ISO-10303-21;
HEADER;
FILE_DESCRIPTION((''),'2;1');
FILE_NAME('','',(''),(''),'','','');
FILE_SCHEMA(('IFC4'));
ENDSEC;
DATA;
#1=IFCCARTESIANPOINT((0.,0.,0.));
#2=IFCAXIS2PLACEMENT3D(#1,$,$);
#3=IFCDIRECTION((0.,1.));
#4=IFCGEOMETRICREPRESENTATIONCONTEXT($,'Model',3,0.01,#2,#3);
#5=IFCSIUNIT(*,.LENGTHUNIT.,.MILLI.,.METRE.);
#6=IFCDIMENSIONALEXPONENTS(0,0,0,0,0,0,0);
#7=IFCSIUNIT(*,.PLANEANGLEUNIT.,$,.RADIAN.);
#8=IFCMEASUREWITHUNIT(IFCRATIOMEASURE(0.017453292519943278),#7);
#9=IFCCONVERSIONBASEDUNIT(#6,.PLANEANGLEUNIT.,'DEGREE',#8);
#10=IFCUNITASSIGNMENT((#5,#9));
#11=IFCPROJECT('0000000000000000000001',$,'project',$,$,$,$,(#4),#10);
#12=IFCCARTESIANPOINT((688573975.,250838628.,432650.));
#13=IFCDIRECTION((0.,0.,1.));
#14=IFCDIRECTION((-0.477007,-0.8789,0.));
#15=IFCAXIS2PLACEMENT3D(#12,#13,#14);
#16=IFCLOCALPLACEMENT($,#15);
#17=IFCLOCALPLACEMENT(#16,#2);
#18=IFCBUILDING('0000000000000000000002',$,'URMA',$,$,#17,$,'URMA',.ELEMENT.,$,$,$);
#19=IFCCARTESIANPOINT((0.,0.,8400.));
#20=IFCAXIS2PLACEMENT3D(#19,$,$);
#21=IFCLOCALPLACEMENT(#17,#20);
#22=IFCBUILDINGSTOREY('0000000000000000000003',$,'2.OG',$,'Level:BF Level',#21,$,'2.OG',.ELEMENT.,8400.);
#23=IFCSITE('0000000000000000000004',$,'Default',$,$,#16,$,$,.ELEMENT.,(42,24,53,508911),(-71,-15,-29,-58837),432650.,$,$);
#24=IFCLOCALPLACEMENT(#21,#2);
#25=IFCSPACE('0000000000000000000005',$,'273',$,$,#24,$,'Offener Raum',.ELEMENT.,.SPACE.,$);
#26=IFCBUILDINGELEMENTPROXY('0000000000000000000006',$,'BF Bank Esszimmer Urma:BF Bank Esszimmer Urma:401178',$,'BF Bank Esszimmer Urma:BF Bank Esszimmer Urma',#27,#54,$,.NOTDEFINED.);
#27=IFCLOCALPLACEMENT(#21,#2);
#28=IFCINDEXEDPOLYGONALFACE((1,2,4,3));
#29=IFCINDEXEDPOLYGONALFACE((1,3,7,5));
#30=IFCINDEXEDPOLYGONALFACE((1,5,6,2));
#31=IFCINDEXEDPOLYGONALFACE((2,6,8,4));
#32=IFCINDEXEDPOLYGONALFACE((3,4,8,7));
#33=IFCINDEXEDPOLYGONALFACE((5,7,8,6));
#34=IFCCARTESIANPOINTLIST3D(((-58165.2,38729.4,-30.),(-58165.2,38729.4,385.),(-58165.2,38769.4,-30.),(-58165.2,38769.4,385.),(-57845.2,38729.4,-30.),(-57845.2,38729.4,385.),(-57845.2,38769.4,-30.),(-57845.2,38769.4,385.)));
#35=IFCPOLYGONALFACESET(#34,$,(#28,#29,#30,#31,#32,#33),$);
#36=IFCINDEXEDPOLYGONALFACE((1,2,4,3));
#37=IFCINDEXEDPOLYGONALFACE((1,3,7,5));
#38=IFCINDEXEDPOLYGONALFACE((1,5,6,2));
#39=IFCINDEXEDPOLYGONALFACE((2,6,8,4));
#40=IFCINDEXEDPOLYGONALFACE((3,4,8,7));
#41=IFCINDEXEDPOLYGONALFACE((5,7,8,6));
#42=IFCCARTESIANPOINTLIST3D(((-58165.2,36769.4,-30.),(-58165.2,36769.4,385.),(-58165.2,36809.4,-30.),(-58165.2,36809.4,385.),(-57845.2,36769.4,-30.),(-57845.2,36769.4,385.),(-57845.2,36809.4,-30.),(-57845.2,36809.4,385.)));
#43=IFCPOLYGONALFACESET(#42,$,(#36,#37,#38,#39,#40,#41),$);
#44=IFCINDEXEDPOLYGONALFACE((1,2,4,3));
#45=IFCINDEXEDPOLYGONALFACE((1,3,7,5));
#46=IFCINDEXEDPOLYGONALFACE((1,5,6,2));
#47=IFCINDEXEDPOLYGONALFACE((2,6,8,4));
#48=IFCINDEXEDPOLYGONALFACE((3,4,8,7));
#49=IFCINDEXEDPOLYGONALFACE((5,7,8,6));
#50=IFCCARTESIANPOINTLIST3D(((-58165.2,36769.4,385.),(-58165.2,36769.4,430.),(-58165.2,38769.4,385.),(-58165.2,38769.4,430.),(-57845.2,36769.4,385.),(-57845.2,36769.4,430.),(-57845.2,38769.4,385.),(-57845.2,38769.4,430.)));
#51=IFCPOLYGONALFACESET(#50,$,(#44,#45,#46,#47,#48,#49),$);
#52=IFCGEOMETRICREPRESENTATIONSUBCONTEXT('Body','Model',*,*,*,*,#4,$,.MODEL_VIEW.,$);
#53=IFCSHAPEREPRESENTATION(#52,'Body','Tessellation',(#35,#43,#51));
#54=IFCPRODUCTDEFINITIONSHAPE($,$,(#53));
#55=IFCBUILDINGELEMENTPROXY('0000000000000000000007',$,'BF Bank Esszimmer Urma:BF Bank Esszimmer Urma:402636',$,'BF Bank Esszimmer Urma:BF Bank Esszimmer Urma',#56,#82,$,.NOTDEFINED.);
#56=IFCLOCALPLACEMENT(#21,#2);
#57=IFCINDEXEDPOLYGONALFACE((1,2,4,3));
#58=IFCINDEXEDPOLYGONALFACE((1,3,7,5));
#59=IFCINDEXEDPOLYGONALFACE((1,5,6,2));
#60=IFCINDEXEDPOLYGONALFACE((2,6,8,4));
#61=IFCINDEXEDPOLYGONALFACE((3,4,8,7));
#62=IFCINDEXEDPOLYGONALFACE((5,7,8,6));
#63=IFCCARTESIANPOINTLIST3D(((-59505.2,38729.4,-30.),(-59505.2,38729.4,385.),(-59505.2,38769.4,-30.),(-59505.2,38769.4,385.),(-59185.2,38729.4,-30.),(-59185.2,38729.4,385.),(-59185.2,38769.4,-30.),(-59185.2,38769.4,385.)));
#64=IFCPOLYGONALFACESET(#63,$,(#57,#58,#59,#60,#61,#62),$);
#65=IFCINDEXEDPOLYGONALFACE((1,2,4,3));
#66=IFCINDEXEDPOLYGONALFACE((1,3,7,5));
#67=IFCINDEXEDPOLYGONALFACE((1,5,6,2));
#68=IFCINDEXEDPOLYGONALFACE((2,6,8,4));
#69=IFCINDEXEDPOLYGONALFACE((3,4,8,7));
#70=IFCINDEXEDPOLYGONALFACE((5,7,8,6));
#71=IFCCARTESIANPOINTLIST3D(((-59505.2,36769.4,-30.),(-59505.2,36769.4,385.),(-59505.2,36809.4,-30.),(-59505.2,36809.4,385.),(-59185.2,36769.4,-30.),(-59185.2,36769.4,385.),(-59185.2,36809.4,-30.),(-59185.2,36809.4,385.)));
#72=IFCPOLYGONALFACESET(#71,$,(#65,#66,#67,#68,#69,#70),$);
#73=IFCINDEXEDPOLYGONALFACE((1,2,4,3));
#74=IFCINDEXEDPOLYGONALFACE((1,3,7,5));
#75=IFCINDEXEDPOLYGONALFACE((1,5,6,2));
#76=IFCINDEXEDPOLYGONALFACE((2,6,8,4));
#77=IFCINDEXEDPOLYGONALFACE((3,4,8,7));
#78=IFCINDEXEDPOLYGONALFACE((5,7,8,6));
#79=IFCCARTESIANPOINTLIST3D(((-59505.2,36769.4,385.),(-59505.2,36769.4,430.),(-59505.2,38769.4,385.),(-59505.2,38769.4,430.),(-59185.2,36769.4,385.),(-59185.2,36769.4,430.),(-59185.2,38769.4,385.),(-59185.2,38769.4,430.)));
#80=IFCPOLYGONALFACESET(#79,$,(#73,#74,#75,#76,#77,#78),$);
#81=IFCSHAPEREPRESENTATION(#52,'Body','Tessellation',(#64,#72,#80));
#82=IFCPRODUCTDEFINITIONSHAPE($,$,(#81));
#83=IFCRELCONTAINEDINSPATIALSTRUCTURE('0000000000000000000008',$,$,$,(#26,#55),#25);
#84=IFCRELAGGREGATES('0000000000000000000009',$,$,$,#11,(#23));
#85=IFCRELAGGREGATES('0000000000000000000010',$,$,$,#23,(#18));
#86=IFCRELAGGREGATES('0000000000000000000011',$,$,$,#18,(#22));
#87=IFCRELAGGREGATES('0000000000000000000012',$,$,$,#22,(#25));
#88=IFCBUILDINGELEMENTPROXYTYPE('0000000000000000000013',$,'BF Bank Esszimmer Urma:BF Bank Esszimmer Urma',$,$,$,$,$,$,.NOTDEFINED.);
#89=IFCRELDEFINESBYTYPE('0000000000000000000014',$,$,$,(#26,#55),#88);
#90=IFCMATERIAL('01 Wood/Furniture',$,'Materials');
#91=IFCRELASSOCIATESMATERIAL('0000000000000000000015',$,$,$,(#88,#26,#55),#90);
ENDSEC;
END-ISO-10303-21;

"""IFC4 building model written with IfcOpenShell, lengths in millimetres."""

from ifc_helpers import new_model, entity, si_unit, converted_unit, direction, frame, origin, place, context, subcontext, project, spatial, indexed_curve, outline, extrude, source, transform, mapped, material, type_object, type_shapes, element, save


model = new_model("IFC4")

# Units and contexts
model_context = context("Model", 3, precision=0.01, world=origin(), true_north=direction((0.0, 1.0)))
body_context = subcontext(model_context, "Body", "Model", "MODEL_VIEW")
ifc_project = project(units=[si_unit("LENGTHUNIT", "METRE", prefix="MILLI"), converted_unit("PLANEANGLEUNIT", "DEGREE", entity("IfcRatioMeasure", 0.017453292519943278), si_unit("PLANEANGLEUNIT", "RADIAN"), dimensions=[0, 0, 0, 0, 0, 0, 0])], contexts=[model_context])

# Site, building, storey
site_placement = place(None, frame((688573975.0, 250838628.0, 432650.0), z_axis=(0.0, 0.0, 1.0), x_axis=(-0.477007, -0.8789, 0.0)))
site = spatial("IfcSite", under=ifc_project, at=site_placement, Name="Default", CompositionType="ELEMENT", RefLatitude=(42, 24, 53, 508911), RefLongitude=(-71, -15, -29, -58837), RefElevation=432650.0)
building_placement = place(site_placement, origin())
building = spatial("IfcBuilding", under=site, at=building_placement, Name="URMA", LongName="URMA", CompositionType="ELEMENT")
storey_placement = place(building_placement, frame((0.0, 0.0, 8400.0)))
storey = spatial("IfcBuildingStorey", under=building, at=storey_placement, Name="2.OG", ObjectType="Level:BF Level", LongName="2.OG", CompositionType="ELEMENT", Elevation=8400.0)

# Shared definitions
space_1_placement = place(storey_placement, origin())
space_1 = spatial("IfcSpace", under=storey, at=space_1_placement, Name="273", LongName="Offener Raum", CompositionType="ELEMENT", PredefinedType="SPACE")

# Building element proxies
ifc_material_1 = material(Name="01 Wood/Furniture", Category="Materials")
building_element_proxy_type_1 = type_object("IfcBuildingElementProxyType", Name="BF Bank Esszimmer Urma:BF Bank Esszimmer Urma", PredefinedType="NOTDEFINED", material=ifc_material_1)
shared_shape_1 = source(origin(), body_context, "Body", "SweptSolid", [
    extrude(outline(indexed_curve([(-160.0, -20.0), (160.0, -20.0), (160.0, 20.0), (-160.0, 20.0), (-160.0, -20.0)], self_intersect=False)), frame((935.3, -1.4, 0.0), z_axis=(0.0, 0.0, 1.0), x_axis=(0.0, 1.0, 0.0)), (0.0, 0.0, 1.0), 415.0),
    extrude(outline(indexed_curve([(-160.0, -20.0), (160.0, -20.0), (160.0, 20.0), (-160.0, 20.0), (-160.0, -20.0)], self_intersect=False)), frame((-1024.7, -1.4, 0.0), z_axis=(0.0, 0.0, 1.0), x_axis=(0.0, 1.0, 0.0)), (0.0, 0.0, 1.0), 415.0),
    extrude(outline(indexed_curve([(-160.0, -1000.0), (160.0, -1000.0), (160.0, 1000.0), (-160.0, 1000.0), (-160.0, -1000.0)], self_intersect=False)), frame((-44.7, -1.4, 415.0), z_axis=(0.0, 0.0, 1.0), x_axis=(0.0, 1.0, 0.0)), (0.0, 0.0, 1.0), 45.0),
])
type_shapes(building_element_proxy_type_1, [shared_shape_1])
for number, where, z_axis, x_axis, name in (
    (1, (-58006.6, 37814.2, -30.0), (0.0, 0.0, 1.0), (0.0, 1.0, 0.0), "BF Bank Esszimmer Urma:BF Bank Esszimmer Urma:401178"),
    (2, (-59346.6, 37814.2, -30.0), (0.0, 0.0, 1.0), (0.0, 1.0, 0.0), "BF Bank Esszimmer Urma:BF Bank Esszimmer Urma:402636"),
):
    element("IfcBuildingElementProxy", number, at=place(space_1_placement, frame(where, z_axis=z_axis, x_axis=x_axis)), inside=space_1, type_object=building_element_proxy_type_1, material=ifc_material_1, Name=name, ObjectType="BF Bank Esszimmer Urma:BF Bank Esszimmer Urma", PredefinedType="NOTDEFINED", context=body_context, shape_type="MappedRepresentation", body=[
        mapped(shared_shape_1, transform((0.0, 0.0, 0.0), scale=1.0)),
    ])

save(model, "model.ifc")
